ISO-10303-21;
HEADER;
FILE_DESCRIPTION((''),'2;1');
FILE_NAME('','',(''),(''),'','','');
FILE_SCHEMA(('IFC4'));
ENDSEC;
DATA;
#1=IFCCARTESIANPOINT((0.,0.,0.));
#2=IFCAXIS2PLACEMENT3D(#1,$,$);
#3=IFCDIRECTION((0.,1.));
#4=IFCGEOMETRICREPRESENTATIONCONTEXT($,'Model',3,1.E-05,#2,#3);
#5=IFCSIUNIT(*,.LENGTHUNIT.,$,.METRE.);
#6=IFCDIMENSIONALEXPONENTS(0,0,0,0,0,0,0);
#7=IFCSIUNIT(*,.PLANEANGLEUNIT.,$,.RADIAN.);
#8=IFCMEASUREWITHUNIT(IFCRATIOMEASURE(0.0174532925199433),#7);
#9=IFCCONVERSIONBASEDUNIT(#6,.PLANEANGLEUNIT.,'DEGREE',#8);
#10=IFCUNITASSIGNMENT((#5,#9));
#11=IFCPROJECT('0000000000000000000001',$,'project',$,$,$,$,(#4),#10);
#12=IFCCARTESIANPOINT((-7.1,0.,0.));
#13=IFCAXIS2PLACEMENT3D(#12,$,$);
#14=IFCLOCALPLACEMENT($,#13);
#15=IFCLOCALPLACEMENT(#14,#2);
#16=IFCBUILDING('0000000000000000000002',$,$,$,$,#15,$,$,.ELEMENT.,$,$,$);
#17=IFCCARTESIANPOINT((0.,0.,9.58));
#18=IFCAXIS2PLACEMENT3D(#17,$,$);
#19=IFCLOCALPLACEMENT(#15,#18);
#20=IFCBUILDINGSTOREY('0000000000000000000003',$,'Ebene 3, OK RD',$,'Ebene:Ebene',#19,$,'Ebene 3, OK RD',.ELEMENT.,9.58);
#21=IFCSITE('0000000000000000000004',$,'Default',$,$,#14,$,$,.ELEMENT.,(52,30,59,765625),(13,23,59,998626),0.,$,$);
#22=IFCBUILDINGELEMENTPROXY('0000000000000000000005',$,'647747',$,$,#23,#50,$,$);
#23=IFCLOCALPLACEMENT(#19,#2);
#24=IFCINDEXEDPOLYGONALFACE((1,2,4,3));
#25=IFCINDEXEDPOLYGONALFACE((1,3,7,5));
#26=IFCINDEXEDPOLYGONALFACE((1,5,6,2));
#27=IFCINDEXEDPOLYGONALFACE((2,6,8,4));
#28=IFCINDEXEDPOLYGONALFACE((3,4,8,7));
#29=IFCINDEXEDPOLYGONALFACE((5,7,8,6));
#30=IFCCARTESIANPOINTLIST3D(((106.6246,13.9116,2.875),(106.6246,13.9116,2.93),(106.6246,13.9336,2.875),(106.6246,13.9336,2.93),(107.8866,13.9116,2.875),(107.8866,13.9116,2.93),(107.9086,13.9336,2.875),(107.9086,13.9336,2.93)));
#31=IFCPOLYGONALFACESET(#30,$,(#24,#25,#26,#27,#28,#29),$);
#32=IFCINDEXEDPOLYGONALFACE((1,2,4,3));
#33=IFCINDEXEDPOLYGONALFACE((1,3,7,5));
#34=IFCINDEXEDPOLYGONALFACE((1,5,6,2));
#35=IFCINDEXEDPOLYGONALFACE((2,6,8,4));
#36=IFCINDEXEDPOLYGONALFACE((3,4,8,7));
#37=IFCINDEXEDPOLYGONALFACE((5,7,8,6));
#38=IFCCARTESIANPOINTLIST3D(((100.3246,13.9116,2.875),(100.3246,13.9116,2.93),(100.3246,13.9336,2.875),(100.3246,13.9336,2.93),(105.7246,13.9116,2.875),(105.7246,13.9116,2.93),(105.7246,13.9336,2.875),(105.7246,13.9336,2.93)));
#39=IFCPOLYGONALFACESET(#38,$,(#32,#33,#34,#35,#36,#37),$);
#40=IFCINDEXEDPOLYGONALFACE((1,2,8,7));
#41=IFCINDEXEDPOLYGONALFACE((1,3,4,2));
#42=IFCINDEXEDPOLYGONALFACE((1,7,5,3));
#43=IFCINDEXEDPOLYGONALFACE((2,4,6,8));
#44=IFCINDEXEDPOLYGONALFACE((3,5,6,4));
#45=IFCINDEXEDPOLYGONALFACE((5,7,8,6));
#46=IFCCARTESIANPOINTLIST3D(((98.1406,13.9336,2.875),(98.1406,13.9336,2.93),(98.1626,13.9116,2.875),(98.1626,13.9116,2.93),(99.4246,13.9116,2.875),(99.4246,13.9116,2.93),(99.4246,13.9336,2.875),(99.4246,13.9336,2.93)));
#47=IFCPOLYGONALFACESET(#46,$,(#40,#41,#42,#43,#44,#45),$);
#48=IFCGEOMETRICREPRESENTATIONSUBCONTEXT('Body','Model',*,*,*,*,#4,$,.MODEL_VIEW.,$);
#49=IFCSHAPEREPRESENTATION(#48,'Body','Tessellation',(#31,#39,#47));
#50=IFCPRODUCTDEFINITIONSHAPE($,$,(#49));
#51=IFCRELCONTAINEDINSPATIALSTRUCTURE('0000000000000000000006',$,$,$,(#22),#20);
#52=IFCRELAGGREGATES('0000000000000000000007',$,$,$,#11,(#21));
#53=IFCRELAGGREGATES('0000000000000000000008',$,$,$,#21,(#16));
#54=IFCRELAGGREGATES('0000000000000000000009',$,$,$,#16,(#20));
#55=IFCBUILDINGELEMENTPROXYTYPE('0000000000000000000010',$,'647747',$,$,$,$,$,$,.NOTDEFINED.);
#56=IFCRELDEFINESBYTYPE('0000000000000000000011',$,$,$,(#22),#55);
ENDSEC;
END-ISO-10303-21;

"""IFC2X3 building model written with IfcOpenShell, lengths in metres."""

from ifc_helpers import new_model, entity, si_unit, converted_unit, direction, frame, frame_2d, origin, place, context, subcontext, project, spatial, polyline, rectangle, outline, extrude, type_object, element, save


model = new_model("IFC2X3")

# Units and contexts
model_context = context("Model", 3, precision=1e-05, world=origin(), true_north=direction((0.0, 1.0)))
body_context = subcontext(model_context, "Body", "Model", "MODEL_VIEW")
ifc_project = project(units=[si_unit("LENGTHUNIT", "METRE"), converted_unit("PLANEANGLEUNIT", "DEGREE", entity("IfcRatioMeasure", 0.0174532925199433), si_unit("PLANEANGLEUNIT", "RADIAN"), dimensions=[0, 0, 0, 0, 0, 0, 0])], contexts=[model_context])

# Site, building, storey
site_placement = place(None, frame((-7.1, 0.0, 0.0)))
site = spatial("IfcSite", under=ifc_project, at=site_placement, Name="Default", CompositionType="ELEMENT", RefLatitude=(52, 30, 59, 765625), RefLongitude=(13, 23, 59, 998626), RefElevation=0.0)
building_placement = place(site_placement, origin())
building = spatial("IfcBuilding", under=site, at=building_placement, CompositionType="ELEMENT")
storey_placement = place(building_placement, frame((0.0, 0.0, 9.58)))
storey = spatial("IfcBuildingStorey", under=building, at=storey_placement, Name="Ebene 3, OK RD", ObjectType="Ebene:Ebene", LongName="Ebene 3, OK RD", CompositionType="ELEMENT", Elevation=9.58)

# Building element proxy
building_element_proxy_type_1 = type_object("IfcBuildingElementProxyType", Name="647747", PredefinedType="NOTDEFINED")
proxy_1_placement = place(storey_placement, origin())
element("IfcBuildingElementProxy", 1, at=proxy_1_placement, inside=storey, type_object=building_element_proxy_type_1, Name="647747", context=body_context, shape_type="SweptSolid", body=[
    extrude(outline(polyline([(-0.6365, -0.011), (0.6255, -0.011), (0.6475, 0.011), (-0.6365, 0.011), (-0.6365, -0.011)])), frame((107.2611, 13.9226, 2.875)), (0.0, 0.0, 1.0), 0.055),
    extrude(rectangle(XDim=5.4, YDim=0.022, at=frame_2d((0.0, 0.0), x_axis=(1.0, 0.0))), frame((103.0246, 13.9226, 2.875)), (0.0, 0.0, 1.0), 0.055),
    extrude(outline(polyline([(-0.6255, -0.011), (0.6365, -0.011), (0.6365, 0.011), (-0.6475, 0.011), (-0.6255, -0.011)])), frame((98.7881, 13.9226, 2.875)), (0.0, 0.0, 1.0), 0.055),
])

save(model, "model.ifc")
